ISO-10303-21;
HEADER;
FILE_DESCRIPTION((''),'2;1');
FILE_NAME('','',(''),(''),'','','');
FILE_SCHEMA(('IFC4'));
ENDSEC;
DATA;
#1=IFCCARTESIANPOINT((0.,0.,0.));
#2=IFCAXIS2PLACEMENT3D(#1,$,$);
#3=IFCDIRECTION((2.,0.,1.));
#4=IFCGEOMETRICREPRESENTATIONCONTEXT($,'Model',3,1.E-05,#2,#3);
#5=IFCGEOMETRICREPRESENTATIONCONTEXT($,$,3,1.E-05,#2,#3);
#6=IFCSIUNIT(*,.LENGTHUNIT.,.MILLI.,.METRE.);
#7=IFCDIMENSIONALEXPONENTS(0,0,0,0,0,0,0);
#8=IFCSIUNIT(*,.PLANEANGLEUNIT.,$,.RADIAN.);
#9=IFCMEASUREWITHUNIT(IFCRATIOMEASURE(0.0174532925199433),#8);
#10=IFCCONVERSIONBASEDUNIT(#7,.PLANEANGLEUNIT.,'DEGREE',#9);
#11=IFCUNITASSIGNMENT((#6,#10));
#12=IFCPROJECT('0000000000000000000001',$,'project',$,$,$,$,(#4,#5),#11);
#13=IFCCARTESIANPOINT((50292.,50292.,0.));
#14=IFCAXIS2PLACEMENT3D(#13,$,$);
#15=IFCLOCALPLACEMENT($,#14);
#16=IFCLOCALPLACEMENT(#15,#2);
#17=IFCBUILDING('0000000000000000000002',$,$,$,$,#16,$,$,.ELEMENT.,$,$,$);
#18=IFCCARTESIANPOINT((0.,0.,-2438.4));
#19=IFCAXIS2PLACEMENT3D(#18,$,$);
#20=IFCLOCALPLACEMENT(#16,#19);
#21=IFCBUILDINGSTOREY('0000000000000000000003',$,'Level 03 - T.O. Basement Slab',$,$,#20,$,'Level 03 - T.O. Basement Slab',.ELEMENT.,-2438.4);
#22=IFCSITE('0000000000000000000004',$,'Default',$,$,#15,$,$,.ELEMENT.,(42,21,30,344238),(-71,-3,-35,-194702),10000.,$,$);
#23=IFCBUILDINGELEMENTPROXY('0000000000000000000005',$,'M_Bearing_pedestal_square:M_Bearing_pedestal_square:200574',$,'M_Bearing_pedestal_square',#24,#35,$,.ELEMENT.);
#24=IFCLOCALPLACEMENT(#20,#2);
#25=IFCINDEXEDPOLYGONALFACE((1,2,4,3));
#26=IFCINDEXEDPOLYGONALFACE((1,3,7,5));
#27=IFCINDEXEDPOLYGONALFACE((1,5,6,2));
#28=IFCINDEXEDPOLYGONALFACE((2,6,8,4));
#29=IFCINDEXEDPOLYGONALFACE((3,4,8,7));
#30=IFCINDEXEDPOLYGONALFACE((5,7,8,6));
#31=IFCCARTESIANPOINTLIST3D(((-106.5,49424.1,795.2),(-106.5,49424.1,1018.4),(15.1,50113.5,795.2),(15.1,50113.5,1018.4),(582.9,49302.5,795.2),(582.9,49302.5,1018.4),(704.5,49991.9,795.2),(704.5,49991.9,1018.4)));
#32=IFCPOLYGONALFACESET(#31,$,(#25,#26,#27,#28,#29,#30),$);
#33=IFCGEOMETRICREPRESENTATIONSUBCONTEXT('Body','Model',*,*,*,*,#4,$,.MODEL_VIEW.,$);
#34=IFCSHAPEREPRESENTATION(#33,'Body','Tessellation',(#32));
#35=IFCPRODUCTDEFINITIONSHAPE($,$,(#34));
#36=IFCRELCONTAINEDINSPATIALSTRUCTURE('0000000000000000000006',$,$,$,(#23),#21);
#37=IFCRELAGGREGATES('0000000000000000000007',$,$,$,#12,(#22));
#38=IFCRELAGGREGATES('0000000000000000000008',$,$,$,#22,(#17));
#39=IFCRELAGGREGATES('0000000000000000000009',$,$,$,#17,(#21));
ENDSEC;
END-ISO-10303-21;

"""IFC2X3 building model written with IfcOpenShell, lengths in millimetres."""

from ifc_helpers import new_model, entity, si_unit, converted_unit, direction, frame, origin, origin_2d_with_axis, place, context, subcontext, project, spatial, rectangle, extrude, source, transform, mapped, element, save


model = new_model("IFC2X3")

# Units and contexts
model_context = context("Model", 3, precision=1e-05, world=origin(), true_north=direction((2.0, 0.0, 1.0)))
context_of_model = context(None, 3, precision=1e-05, world=origin(), true_north=direction((2.0, 0.0, 1.0)))
body_context = subcontext(model_context, "Body", "Model", "MODEL_VIEW")
ifc_project = project(units=[si_unit("LENGTHUNIT", "METRE", prefix="MILLI"), converted_unit("PLANEANGLEUNIT", "DEGREE", entity("IfcRatioMeasure", 0.0174532925199433), si_unit("PLANEANGLEUNIT", "RADIAN"), dimensions=[0, 0, 0, 0, 0, 0, 0])], contexts=[model_context, context_of_model])

# Site, building, storey
site_placement = place(None, frame((50292.0, 50292.0, 0.0)))
site = spatial("IfcSite", under=ifc_project, at=site_placement, Name="Default", CompositionType="ELEMENT", RefLatitude=(42, 21, 30, 344238), RefLongitude=(-71, -3, -35, -194702), RefElevation=10000.0)
building_placement = place(site_placement, origin())
building = spatial("IfcBuilding", under=site, at=building_placement, CompositionType="ELEMENT")
storey_placement = place(building_placement, frame((0.0, 0.0, -2438.4)))
storey = spatial("IfcBuildingStorey", under=building, at=storey_placement, Name="Level 03 - T.O. Basement Slab", LongName="Level 03 - T.O. Basement Slab", CompositionType="ELEMENT", Elevation=-2438.4)

# Building element proxy
shared_shape_1 = source(origin(), body_context, "Body", "SweptSolid", [
    extrude(rectangle(XDim=700.0, YDim=700.0, at=origin_2d_with_axis()), frame((0.0, 0.0, -223.2)), (0.0, 0.0, 1.0), 223.2),
])
proxy_1_placement = place(storey_placement, frame((299.0, 49708.0, 1018.4), z_axis=(0.0, 0.0, 1.0), x_axis=(0.173648, 0.984808, 0.0)))
element("IfcBuildingElementProxy", 1, at=proxy_1_placement, inside=storey, Name="M_Bearing_pedestal_square:M_Bearing_pedestal_square:200574", ObjectType="M_Bearing_pedestal_square", CompositionType="ELEMENT", context=body_context, shape_type="MappedRepresentation", body=[
    mapped(shared_shape_1, transform((0.0, 0.0, 0.0), scale=1.0)),
])

save(model, "model.ifc")
